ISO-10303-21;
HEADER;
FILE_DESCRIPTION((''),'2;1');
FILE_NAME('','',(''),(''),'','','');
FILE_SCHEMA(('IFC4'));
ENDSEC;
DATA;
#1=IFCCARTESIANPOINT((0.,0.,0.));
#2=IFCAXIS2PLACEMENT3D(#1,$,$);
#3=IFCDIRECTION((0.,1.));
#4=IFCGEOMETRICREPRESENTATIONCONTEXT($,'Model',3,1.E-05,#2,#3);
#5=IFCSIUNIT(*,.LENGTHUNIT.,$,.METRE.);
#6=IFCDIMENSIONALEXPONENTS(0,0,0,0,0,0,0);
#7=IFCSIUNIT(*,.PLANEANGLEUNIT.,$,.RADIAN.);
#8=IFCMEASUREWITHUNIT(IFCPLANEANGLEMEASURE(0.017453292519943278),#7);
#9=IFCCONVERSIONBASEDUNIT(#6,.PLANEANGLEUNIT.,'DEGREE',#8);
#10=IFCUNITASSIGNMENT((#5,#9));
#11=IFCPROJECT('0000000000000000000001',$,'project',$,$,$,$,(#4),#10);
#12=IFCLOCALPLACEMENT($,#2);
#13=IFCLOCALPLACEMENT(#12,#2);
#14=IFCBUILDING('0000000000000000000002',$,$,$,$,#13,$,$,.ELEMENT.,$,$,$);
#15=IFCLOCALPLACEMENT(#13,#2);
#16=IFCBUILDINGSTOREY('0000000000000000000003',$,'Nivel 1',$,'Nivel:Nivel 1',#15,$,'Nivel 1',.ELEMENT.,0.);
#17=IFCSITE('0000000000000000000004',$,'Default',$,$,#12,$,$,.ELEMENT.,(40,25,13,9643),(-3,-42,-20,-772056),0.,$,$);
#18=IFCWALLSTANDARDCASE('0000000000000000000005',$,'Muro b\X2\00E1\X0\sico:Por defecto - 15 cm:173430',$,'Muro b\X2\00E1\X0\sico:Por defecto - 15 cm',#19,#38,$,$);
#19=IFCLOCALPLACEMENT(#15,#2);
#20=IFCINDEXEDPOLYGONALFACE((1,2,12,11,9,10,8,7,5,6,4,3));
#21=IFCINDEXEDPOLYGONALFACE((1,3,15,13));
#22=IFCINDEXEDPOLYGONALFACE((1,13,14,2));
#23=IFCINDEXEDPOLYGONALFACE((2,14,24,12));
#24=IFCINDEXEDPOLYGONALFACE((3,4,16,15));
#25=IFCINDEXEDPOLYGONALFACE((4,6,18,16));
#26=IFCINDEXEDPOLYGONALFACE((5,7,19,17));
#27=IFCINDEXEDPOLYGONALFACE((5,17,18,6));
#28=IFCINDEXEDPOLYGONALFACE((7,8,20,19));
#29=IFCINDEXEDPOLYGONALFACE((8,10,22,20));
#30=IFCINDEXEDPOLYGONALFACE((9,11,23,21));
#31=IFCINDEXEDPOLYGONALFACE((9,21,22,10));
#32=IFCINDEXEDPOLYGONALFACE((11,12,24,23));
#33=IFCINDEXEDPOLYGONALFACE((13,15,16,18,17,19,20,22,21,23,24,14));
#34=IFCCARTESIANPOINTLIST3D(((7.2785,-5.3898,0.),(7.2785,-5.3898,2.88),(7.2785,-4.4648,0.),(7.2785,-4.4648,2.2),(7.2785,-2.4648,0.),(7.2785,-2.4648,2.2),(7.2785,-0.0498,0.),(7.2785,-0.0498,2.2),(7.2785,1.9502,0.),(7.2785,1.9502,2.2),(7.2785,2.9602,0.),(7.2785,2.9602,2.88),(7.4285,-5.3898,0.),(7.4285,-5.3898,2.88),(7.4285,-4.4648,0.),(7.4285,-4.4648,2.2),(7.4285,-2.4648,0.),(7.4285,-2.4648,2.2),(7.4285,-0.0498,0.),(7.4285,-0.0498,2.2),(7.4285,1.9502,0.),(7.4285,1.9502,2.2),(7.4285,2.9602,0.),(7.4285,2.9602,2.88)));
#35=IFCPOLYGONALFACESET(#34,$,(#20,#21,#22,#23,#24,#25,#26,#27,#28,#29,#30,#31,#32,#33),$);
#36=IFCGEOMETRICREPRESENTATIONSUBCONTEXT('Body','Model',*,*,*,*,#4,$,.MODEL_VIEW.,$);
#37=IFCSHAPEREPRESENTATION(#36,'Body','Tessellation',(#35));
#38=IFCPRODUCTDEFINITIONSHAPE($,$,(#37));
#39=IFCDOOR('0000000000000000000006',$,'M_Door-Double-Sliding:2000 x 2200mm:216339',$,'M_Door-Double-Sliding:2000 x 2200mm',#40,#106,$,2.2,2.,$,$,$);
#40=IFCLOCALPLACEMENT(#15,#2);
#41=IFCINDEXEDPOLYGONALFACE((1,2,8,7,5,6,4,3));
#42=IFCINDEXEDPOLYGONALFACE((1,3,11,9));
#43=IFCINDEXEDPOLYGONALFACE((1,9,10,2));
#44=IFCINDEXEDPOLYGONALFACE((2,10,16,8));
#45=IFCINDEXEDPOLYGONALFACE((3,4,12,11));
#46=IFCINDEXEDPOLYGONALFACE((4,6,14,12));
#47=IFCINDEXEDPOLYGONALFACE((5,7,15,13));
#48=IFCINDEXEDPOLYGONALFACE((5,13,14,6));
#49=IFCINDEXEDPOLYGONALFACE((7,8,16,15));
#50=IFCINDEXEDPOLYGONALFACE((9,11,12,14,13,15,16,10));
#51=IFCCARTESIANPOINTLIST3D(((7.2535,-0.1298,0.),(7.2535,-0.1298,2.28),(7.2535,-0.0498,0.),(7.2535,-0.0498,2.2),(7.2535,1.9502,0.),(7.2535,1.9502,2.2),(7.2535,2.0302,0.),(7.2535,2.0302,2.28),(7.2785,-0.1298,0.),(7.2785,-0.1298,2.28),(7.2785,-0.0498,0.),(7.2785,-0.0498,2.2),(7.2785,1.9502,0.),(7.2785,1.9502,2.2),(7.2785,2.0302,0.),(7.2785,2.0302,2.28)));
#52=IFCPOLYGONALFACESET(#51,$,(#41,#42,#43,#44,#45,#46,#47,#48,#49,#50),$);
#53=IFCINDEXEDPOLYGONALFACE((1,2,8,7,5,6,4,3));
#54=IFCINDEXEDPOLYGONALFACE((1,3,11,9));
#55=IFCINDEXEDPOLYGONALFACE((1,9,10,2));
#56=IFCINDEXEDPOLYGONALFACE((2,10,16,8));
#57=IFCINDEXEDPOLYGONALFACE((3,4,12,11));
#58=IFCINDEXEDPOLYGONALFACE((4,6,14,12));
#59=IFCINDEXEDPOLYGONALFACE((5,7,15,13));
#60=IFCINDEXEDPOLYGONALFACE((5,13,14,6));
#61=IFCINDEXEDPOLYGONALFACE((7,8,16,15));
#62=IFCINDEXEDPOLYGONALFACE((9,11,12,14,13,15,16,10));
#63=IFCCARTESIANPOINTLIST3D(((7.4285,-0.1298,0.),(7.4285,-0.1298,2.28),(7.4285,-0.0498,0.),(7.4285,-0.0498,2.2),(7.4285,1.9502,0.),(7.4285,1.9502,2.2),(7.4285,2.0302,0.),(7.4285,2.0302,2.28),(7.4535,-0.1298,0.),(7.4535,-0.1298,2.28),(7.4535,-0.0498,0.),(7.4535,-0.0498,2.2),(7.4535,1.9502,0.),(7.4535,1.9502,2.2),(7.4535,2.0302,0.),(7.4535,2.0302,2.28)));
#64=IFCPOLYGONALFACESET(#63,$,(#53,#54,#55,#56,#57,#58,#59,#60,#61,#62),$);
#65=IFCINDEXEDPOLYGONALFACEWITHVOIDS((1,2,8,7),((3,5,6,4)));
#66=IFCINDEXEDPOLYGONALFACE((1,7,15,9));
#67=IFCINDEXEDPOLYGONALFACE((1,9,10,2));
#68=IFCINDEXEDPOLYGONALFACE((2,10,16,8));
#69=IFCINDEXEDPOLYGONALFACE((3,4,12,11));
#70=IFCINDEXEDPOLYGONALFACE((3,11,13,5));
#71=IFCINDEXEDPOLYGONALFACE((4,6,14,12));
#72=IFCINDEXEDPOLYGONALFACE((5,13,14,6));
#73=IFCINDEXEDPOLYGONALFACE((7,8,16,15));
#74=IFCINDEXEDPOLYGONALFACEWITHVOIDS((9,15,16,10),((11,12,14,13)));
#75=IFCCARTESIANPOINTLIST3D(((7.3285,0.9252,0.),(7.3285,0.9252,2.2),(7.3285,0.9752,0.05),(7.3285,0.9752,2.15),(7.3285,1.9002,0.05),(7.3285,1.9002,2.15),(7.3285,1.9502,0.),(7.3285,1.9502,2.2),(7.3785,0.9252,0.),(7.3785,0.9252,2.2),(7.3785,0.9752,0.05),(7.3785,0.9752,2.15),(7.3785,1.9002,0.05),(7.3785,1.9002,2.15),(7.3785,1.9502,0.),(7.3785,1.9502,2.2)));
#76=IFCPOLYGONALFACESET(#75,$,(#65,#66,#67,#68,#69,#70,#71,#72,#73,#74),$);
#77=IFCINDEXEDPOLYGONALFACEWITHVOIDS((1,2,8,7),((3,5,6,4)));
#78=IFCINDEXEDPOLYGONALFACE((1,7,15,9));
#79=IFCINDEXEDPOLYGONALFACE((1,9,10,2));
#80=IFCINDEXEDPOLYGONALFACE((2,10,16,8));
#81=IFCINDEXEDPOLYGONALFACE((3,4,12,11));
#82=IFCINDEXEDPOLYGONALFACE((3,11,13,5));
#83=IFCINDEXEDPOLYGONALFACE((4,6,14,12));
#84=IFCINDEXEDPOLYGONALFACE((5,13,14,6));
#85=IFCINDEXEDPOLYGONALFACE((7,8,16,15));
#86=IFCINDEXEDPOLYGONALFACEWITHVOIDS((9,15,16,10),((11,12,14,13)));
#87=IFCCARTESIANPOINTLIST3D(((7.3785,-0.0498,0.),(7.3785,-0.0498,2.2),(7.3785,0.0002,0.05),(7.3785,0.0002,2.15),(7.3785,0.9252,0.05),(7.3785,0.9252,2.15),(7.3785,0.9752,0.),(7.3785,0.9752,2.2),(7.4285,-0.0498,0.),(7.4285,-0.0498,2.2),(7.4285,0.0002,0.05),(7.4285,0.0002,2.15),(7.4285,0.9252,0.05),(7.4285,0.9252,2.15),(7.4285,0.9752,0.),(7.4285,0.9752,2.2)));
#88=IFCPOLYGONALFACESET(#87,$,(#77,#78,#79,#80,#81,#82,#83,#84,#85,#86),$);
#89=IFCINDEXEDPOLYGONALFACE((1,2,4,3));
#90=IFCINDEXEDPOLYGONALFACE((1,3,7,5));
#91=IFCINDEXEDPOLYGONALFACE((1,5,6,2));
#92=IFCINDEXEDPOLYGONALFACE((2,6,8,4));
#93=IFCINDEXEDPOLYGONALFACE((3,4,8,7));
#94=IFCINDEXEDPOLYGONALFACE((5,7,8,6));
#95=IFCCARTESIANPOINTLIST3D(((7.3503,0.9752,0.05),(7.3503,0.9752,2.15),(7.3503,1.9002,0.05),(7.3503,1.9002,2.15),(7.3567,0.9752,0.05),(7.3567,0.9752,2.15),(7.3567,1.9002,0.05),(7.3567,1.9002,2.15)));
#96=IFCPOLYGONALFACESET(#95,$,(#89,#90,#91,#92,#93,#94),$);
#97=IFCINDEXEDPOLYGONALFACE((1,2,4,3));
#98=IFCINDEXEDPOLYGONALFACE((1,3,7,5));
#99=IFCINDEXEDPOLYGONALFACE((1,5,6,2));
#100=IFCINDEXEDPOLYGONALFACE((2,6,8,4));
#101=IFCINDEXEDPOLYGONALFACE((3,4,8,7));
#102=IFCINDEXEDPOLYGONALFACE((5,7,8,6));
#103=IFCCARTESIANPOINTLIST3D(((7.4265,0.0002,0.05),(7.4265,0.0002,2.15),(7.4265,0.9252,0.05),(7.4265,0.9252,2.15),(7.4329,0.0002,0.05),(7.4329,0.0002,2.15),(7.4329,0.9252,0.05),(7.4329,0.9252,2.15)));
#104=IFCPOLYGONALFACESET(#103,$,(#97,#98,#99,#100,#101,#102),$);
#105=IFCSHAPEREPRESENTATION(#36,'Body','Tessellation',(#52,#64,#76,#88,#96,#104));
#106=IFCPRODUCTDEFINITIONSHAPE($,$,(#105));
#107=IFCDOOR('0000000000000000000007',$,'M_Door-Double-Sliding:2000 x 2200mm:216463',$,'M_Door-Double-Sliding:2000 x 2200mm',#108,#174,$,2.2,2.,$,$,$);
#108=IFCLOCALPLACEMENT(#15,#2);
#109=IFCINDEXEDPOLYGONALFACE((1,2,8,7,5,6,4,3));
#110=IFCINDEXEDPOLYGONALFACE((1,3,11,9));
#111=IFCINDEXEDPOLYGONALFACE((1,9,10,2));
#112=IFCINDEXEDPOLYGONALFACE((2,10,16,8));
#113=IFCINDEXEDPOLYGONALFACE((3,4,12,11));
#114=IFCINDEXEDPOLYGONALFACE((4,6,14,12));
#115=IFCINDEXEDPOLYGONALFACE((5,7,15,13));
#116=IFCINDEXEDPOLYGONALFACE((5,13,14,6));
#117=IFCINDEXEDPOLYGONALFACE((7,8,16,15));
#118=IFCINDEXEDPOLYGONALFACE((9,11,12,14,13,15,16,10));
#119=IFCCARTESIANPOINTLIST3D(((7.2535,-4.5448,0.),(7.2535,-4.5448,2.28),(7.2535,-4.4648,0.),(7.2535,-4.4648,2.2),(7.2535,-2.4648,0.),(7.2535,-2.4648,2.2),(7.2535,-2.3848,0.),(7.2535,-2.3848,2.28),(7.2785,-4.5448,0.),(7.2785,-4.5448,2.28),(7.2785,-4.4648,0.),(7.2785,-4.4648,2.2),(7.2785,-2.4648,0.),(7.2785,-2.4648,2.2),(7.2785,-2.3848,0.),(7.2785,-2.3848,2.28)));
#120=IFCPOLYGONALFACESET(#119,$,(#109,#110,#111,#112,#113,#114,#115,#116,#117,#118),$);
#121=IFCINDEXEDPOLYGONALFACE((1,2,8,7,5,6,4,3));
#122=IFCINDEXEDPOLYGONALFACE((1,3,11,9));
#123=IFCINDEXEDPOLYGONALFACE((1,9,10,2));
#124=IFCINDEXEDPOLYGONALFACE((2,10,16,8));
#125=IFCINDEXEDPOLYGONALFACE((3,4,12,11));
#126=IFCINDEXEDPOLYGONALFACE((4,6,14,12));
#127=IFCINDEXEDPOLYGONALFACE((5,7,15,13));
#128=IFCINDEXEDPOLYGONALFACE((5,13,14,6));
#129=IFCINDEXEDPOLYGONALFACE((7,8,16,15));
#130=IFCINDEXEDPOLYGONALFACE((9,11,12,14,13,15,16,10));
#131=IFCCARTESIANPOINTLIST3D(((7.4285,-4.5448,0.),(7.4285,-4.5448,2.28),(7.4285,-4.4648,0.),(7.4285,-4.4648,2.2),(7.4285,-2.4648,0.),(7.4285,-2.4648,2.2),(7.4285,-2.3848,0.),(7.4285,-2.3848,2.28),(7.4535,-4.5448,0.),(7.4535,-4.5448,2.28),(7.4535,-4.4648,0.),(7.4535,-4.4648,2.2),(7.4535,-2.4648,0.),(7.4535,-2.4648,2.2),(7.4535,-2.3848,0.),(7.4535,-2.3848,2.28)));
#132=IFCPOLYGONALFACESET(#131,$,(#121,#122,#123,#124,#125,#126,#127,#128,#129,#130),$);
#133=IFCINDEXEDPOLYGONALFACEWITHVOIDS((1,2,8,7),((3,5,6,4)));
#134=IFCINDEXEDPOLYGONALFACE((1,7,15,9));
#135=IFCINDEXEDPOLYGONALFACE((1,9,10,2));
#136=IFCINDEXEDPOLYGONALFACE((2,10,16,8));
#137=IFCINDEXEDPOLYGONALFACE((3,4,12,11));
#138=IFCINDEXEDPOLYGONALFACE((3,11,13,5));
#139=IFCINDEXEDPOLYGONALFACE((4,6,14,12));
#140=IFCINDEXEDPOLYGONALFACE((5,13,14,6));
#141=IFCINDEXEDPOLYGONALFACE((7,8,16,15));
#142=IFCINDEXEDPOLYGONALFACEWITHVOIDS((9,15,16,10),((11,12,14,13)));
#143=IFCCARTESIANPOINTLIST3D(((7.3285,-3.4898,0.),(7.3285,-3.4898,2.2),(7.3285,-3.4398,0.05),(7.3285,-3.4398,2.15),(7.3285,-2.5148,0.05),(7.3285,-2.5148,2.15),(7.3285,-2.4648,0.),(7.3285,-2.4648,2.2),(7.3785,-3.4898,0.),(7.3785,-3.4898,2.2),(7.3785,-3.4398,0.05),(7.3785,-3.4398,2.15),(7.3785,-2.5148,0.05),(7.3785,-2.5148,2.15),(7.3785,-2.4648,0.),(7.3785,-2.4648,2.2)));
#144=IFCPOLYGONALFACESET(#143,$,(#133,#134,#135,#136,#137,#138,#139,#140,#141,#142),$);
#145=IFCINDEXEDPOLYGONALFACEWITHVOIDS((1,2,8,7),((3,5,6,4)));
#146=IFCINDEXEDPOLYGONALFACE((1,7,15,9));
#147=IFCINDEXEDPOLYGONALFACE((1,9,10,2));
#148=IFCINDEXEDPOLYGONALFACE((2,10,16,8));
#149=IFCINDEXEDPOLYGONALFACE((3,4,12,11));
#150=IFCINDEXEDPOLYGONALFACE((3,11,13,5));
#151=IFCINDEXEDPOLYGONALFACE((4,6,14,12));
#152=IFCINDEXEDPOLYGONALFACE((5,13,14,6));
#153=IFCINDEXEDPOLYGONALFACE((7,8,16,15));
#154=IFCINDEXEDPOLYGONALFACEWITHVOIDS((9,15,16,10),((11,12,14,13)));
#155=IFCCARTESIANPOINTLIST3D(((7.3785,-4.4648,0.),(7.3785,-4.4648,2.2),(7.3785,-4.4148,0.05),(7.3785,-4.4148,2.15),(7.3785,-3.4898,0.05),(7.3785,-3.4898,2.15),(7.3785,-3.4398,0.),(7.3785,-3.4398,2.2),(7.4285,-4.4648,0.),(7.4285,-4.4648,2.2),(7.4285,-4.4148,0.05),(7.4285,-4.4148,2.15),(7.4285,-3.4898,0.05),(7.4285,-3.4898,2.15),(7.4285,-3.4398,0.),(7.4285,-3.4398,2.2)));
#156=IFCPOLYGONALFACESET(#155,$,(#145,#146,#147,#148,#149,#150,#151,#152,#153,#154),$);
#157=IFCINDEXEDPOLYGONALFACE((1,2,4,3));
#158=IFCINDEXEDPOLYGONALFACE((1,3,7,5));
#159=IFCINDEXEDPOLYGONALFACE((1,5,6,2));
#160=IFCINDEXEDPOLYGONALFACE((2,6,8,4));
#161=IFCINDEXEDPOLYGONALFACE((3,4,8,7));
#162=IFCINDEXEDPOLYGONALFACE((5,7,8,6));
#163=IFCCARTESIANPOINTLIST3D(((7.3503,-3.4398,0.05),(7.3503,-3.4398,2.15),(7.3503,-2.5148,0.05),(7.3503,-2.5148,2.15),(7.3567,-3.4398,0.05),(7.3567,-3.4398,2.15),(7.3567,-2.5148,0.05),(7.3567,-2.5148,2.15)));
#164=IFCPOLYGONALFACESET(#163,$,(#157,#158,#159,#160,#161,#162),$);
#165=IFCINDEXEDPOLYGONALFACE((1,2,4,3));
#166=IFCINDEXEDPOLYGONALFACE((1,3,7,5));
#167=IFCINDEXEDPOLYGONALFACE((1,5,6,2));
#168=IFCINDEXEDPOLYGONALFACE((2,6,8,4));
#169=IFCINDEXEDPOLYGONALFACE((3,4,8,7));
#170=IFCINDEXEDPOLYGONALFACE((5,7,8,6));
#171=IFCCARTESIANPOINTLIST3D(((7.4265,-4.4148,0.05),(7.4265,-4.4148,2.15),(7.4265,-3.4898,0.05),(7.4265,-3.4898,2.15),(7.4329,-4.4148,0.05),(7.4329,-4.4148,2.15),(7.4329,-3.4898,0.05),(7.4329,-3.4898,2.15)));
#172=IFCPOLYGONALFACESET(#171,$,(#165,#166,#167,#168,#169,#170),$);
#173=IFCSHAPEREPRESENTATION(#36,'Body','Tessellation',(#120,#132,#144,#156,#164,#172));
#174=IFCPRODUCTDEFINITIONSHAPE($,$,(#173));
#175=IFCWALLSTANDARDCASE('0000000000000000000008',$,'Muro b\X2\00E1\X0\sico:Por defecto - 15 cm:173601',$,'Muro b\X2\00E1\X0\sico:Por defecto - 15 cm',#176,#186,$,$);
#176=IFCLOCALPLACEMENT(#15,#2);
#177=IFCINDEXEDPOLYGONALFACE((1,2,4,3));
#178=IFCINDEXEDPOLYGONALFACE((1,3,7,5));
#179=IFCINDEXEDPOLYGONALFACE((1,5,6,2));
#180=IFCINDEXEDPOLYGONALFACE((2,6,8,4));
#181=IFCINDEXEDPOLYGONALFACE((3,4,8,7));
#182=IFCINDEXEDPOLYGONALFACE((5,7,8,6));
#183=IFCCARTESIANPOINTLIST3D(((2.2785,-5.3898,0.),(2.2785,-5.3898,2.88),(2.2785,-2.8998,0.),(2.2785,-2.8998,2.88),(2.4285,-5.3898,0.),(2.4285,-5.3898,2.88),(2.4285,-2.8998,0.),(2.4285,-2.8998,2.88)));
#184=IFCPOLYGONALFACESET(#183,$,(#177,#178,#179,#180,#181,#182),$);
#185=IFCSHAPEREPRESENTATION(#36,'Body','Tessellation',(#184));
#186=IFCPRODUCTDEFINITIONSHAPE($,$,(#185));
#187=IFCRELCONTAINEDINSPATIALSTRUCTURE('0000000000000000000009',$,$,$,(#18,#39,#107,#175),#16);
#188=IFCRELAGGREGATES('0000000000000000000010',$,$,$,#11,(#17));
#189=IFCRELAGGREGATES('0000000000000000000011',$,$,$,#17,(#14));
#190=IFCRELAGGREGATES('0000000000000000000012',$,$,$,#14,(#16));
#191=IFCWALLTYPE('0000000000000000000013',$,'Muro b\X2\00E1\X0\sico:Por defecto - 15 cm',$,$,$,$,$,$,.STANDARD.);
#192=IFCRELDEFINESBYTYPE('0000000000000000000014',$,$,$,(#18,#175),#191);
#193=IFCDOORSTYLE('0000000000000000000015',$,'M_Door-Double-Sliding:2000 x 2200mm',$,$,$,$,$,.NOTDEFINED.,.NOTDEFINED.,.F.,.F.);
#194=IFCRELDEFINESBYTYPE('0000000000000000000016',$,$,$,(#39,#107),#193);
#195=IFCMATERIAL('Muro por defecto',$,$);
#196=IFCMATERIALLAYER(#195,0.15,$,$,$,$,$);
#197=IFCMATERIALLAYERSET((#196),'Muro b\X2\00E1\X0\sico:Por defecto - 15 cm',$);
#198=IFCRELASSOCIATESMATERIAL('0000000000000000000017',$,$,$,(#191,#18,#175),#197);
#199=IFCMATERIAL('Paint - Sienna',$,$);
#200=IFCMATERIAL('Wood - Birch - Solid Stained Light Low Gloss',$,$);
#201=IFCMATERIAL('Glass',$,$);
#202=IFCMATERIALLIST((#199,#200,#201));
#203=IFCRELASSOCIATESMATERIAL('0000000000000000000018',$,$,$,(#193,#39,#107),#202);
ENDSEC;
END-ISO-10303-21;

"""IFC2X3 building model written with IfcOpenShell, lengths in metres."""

from ifc_helpers import new_model, entity, si_unit, converted_unit, direction, frame, frame_2d, origin, origin_2d_with_axis, place, context, subcontext, project, spatial, polyline, rectangle, outline, extrude, clip, bounded_halfspace, source, transform, mapped, material, material_list, layer, layer_set, layer_usage, type_object, type_shapes, element, fill, save


model = new_model("IFC2X3")

# Units and contexts
model_context = context("Model", 3, precision=1e-05, world=origin(), true_north=direction((0.0, 1.0)))
body_context = subcontext(model_context, "Body", "Model", "MODEL_VIEW")
ifc_project = project(units=[si_unit("LENGTHUNIT", "METRE"), converted_unit("PLANEANGLEUNIT", "DEGREE", entity("IfcPlaneAngleMeasure", 0.017453292519943278), si_unit("PLANEANGLEUNIT", "RADIAN"), dimensions=[0, 0, 0, 0, 0, 0, 0])], contexts=[model_context])

# Site, building, storey
site_placement = place(None, origin())
site = spatial("IfcSite", under=ifc_project, at=site_placement, Name="Default", CompositionType="ELEMENT", RefLatitude=(40, 25, 13, 9643), RefLongitude=(-3, -42, -20, -772056), RefElevation=0.0)
building_placement = place(site_placement, origin())
building = spatial("IfcBuilding", under=site, at=building_placement, CompositionType="ELEMENT")
storey_placement = place(building_placement, origin())
storey = spatial("IfcBuildingStorey", under=building, at=storey_placement, Name="Nivel 1", ObjectType="Nivel:Nivel 1", LongName="Nivel 1", CompositionType="ELEMENT", Elevation=0.0)

# Shared definitions
ifc_material_1 = material(Name="Muro por defecto")
ifc_layer = layer(ifc_material_1, 0.15)
ifc_layer_set = layer_set([ifc_layer], Name="Muro básico:Por defecto - 15 cm")
wall_type = type_object("IfcWallType", Name="Muro básico:Por defecto - 15 cm", PredefinedType="STANDARD", material=ifc_layer_set)

# Shared definitions
ifc_material_2 = material(Name="Wood - Birch - Solid Stained Light Low Gloss")
ifc_material_3 = material(Name="Paint - Sienna")

# Wall, openings, doors
ifc_layer_usage_1 = layer_usage(ifc_layer_set, "AXIS2", "NEGATIVE", 0.075)
wall_1_placement = place(storey_placement, frame((7.3535, 2.9602, 0.0), z_axis=(0.0, 0.0, 1.0), x_axis=(0.0, -1.0, 0.0)))
wall_1 = element("IfcWallStandardCase", 1, at=wall_1_placement, inside=storey, type_object=wall_type, material=ifc_layer_usage_1, Name="Muro básico:Por defecto - 15 cm:173430", ObjectType="Muro básico:Por defecto - 15 cm", context=body_context, shape_type="Clipping", body=[
    clip(extrude(rectangle(XDim=8.35, YDim=0.15, at=frame_2d((4.175, 0.0), x_axis=(-1.0, 0.0))), origin(), (0.0, 0.0, 1.0), 2.88), bounded_halfspace(frame((0.0, -0.075, 2.88), z_axis=(0.0, 0.0, -1.0), x_axis=(0.0, 1.0, 0.0)), True, frame((0.0, -0.075, 2.88)), polyline([(0.0, 0.0), (8.35, 0.0), (8.35, 0.15), (0.0, 0.15), (0.0, 0.0)]))),
])
opening_1_placement = place(wall_1_placement, frame((1.01, -0.075, 0.0)))
opening_1 = element("IfcOpeningElement", 2, at=opening_1_placement, cuts=wall_1, ObjectType="Opening", context=body_context, shape_type="SweptSolid", body=[
    extrude(rectangle(XDim=2.2, YDim=2.0, at=frame_2d((1.1, 1.0), x_axis=(-1.0, 0.0))), frame((0.0, 0.0, 0.0), z_axis=(0.0, 1.0, 0.0), x_axis=(0.0, 0.0, 1.0)), (0.0, 0.0, 1.0), 0.15),
])
opening_2_placement = place(wall_1_placement, frame((5.425, -0.075, 0.0)))
opening_2 = element("IfcOpeningElement", 3, at=opening_2_placement, cuts=wall_1, ObjectType="Opening", context=body_context, shape_type="SweptSolid", body=[
    extrude(rectangle(XDim=2.2, YDim=2.0, at=frame_2d((1.1, 1.0), x_axis=(-1.0, 0.0))), frame((0.0, 0.0, 0.0), z_axis=(0.0, 1.0, 0.0), x_axis=(0.0, 0.0, 1.0)), (0.0, 0.0, 1.0), 0.15),
])
ifc_material_4 = material(Name="Glass")
ifc_material_list_1 = material_list([ifc_material_3, ifc_material_2, ifc_material_4])
door_style_1 = type_object("IfcDoorStyle", Name="M_Door-Double-Sliding:2000 x 2200mm", ConstructionType="NOTDEFINED", OperationType="NOTDEFINED", ParameterTakesPrecedence=False, Sizeable=False, material=ifc_material_list_1)
shared_shape_1 = source(origin(), body_context, "Body", "SweptSolid", [
    extrude(outline(polyline([(-1.12, -1.08), (1.16, -1.08), (1.16, 1.08), (-1.12, 1.08), (-1.12, 1.0), (1.08, 1.0), (1.08, -1.0), (-1.12, -1.0), (-1.12, -1.08)])), frame((1.0, 0.254, 1.12), z_axis=(0.0, -1.0, 0.0), x_axis=(0.0, 0.0, 1.0)), (0.0, 0.0, 1.0), 0.025),
    extrude(outline(polyline([(-1.08, -1.12), (-1.0, -1.12), (-1.0, 1.08), (1.0, 1.08), (1.0, -1.12), (1.08, -1.12), (1.08, 1.16), (-1.08, 1.16), (-1.08, -1.12)])), frame((1.0, 0.429, 1.12), z_axis=(0.0, -1.0, 0.0), x_axis=(1.0, 0.0, 0.0)), (0.0, 0.0, 1.0), 0.025),
    extrude(outline(polyline([(-0.5125, -1.1), (0.5125, -1.1), (0.5125, 1.1), (-0.5125, 1.1), (-0.5125, -1.1)]), holes=[polyline([(-0.4625, -1.05), (-0.4625, 1.05), (0.4625, 1.05), (0.4625, -1.05), (-0.4625, -1.05)])]), frame((0.5125, 0.354, 1.1), z_axis=(0.0, -1.0, 0.0), x_axis=(-1.0, 0.0, 0.0)), (0.0, 0.0, 1.0), 0.05),
    extrude(outline(polyline([(-1.1, -0.5125), (1.1, -0.5125), (1.1, 0.5125), (-1.1, 0.5125), (-1.1, -0.5125)]), holes=[polyline([(-1.05, -0.4625), (-1.05, 0.4625), (1.05, 0.4625), (1.05, -0.4625), (-1.05, -0.4625)])]), frame((1.4875, 0.404, 1.1), z_axis=(0.0, -1.0, 0.0), x_axis=(0.0, 0.0, -1.0)), (0.0, 0.0, 1.0), 0.05),
    extrude(rectangle(XDim=0.925, YDim=0.0063, at=origin_2d_with_axis()), frame((0.5125, 0.329, 0.05), z_axis=(0.0, 0.0, 1.0), x_axis=(-1.0, 0.0, 0.0)), (0.0, 0.0, 1.0), 2.1),
    extrude(rectangle(XDim=0.925, YDim=0.0064, at=origin_2d_with_axis()), frame((1.4875, 0.4052, 0.05)), (0.0, 0.0, 1.0), 2.1),
])
type_shapes(door_style_1, [shared_shape_1])
door_1_placement = place(opening_1_placement, frame((0.0, -0.254, 0.0)))
door_1 = element("IfcDoor", 4, at=door_1_placement, inside=storey, type_object=door_style_1, material=ifc_material_list_1, Name="M_Door-Double-Sliding:2000 x 2200mm:216339", ObjectType="M_Door-Double-Sliding:2000 x 2200mm", OverallHeight=2.2, OverallWidth=2.0, context=body_context, shape_type="MappedRepresentation", body=[
    mapped(shared_shape_1, transform((0.0, 0.0, 0.0), scale=1.0)),
])
fill(opening_1, door_1)
door_2_placement = place(opening_2_placement, frame((0.0, -0.254, 0.0)))
door_2 = element("IfcDoor", 5, at=door_2_placement, inside=storey, type_object=door_style_1, material=ifc_material_list_1, Name="M_Door-Double-Sliding:2000 x 2200mm:216463", ObjectType="M_Door-Double-Sliding:2000 x 2200mm", OverallHeight=2.2, OverallWidth=2.0, context=body_context, shape_type="MappedRepresentation", body=[
    mapped(shared_shape_1, transform((0.0, 0.0, 0.0), scale=1.0)),
])
fill(opening_2, door_2)

# Wall
ifc_layer_usage_2 = layer_usage(ifc_layer_set, "AXIS2", "POSITIVE", -0.075)
wall_2_placement = place(storey_placement, frame((2.3535, -5.3898, 0.0), z_axis=(0.0, 0.0, 1.0), x_axis=(0.0, 1.0, 0.0)))
element("IfcWallStandardCase", 6, at=wall_2_placement, inside=storey, type_object=wall_type, material=ifc_layer_usage_2, Name="Muro básico:Por defecto - 15 cm:173601", ObjectType="Muro básico:Por defecto - 15 cm", context=body_context, shape_type="Clipping", body=[
    clip(extrude(rectangle(XDim=2.49, YDim=0.15, at=frame_2d((1.245, 0.0), x_axis=(-1.0, 0.0))), origin(), (0.0, 0.0, 1.0), 2.88), bounded_halfspace(frame((0.0, -0.075, 2.88), z_axis=(0.0, 0.0, -1.0), x_axis=(0.0, -1.0, 0.0)), True, frame((0.0, -0.075, 2.88)), polyline([(0.0, 0.0), (2.49, 0.0), (2.49, 0.15), (0.0, 0.15), (0.0, 0.0)]))),
])

save(model, "model.ifc")
